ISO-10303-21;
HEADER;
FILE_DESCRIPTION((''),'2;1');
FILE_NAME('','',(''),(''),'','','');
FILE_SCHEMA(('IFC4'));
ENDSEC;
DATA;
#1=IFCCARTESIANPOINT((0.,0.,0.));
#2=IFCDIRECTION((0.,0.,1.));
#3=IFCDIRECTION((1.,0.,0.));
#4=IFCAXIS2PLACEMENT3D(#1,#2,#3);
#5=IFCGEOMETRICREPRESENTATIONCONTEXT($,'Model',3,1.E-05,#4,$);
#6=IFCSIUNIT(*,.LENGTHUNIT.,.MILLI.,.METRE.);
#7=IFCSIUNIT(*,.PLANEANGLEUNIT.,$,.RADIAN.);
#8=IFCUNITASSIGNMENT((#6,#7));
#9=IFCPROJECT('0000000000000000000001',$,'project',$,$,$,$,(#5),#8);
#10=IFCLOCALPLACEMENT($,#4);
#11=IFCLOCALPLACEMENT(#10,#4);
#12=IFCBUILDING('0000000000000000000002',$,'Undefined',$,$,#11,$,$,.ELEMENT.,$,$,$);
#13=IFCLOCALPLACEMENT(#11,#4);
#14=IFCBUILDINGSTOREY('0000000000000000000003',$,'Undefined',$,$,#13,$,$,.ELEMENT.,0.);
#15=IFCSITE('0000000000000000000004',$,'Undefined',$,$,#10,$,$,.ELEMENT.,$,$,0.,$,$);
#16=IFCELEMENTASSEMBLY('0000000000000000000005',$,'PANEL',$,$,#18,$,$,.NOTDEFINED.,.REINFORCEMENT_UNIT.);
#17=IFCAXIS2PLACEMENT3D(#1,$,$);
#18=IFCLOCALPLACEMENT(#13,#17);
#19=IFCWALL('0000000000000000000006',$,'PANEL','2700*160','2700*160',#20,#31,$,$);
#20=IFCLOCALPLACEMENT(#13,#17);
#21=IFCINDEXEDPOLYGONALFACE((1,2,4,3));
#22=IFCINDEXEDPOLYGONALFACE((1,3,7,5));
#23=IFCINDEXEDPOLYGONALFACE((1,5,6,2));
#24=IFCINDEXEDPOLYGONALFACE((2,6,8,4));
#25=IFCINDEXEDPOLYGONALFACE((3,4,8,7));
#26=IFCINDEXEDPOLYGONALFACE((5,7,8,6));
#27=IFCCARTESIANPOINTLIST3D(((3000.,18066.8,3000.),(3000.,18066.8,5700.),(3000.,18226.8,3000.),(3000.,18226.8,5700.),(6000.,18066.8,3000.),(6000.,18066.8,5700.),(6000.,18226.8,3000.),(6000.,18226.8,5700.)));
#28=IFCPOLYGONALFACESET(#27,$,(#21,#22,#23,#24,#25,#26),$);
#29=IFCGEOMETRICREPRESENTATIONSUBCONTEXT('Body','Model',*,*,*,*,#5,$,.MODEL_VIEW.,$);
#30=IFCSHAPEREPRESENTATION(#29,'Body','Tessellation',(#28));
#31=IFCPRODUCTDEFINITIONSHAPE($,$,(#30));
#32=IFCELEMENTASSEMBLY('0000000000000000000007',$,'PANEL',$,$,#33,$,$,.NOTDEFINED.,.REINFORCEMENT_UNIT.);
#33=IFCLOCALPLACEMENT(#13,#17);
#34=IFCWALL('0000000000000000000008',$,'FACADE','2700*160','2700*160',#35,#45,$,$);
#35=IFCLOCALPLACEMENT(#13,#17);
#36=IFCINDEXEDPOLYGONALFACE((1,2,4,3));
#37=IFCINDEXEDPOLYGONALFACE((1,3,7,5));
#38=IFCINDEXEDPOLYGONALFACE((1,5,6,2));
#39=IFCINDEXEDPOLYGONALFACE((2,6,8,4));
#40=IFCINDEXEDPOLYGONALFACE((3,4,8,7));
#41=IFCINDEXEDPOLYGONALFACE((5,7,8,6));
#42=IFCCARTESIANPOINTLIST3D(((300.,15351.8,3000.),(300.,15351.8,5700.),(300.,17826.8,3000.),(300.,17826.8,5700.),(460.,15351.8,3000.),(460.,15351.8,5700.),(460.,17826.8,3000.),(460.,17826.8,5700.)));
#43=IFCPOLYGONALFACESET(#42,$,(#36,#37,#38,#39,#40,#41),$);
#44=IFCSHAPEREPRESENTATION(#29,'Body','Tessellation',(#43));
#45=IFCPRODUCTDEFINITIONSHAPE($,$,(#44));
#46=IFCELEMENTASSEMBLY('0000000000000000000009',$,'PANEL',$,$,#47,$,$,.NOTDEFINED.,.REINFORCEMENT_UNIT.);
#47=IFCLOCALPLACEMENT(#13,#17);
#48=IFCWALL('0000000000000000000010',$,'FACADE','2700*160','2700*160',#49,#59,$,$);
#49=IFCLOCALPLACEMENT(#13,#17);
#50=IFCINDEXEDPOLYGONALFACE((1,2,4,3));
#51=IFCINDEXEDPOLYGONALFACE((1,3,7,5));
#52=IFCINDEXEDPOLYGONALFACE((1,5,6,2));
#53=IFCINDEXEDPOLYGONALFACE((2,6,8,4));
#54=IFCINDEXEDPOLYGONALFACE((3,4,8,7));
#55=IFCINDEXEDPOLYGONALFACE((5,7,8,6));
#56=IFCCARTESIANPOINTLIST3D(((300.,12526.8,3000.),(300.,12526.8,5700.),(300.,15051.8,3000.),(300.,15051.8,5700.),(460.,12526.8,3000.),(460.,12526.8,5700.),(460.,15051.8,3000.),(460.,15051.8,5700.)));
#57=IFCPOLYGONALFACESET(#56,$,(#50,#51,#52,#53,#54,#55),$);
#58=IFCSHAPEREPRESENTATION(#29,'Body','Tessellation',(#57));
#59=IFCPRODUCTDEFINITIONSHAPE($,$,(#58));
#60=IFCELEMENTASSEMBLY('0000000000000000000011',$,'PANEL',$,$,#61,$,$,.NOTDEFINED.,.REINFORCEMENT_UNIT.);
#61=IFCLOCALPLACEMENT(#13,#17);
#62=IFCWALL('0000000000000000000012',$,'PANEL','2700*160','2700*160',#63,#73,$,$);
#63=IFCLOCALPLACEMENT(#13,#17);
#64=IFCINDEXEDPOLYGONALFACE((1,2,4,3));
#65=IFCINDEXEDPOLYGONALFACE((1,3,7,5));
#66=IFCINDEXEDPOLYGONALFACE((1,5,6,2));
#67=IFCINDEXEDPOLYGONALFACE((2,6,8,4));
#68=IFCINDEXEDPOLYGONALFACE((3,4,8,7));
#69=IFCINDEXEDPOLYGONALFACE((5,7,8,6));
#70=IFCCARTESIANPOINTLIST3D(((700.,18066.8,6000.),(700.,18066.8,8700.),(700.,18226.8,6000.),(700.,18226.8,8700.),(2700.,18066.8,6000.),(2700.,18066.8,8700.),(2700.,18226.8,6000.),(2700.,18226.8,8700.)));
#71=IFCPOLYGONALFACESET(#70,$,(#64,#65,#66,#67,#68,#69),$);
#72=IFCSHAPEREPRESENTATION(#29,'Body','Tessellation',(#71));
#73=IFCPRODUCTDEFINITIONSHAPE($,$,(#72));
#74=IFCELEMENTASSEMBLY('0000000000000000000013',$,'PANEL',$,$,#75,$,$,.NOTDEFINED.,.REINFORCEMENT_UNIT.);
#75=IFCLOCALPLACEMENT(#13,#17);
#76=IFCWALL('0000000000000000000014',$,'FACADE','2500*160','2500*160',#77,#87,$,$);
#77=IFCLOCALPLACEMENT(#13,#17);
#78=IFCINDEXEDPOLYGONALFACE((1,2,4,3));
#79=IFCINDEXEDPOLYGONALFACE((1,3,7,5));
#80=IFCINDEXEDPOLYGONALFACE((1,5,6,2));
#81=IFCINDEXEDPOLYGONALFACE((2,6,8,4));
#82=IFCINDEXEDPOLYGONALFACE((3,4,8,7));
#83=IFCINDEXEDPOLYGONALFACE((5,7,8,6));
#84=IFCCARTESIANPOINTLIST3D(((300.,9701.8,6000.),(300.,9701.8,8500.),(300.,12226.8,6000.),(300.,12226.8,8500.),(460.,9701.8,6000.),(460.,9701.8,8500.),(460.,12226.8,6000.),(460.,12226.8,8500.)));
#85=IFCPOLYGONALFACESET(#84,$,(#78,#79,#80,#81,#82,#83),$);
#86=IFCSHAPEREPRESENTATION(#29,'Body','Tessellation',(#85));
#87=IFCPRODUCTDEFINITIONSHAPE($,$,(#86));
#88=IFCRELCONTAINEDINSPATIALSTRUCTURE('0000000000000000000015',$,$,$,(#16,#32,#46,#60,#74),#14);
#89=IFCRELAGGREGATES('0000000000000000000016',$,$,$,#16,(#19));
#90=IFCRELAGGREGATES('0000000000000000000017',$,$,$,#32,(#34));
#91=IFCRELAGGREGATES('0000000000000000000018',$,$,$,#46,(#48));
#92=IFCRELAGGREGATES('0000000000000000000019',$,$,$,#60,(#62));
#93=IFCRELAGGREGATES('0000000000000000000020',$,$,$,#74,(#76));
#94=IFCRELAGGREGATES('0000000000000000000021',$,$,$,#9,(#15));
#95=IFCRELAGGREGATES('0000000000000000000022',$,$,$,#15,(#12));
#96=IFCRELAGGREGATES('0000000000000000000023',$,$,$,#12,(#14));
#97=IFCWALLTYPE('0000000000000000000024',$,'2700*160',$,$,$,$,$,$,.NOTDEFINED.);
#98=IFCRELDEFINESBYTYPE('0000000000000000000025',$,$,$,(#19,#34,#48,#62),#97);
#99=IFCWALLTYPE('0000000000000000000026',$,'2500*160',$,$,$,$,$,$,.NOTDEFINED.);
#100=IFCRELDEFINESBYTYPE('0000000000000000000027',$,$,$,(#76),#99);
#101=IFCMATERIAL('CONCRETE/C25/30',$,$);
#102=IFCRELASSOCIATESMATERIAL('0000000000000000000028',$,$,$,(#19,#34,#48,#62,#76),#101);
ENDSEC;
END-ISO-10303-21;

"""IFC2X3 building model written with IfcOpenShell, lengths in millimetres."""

from ifc_helpers import new_model, si_unit, frame, frame_2d, origin_with_axes, place, context, subcontext, project, spatial, rectangle, extrude, material, type_object, element, aggregate, save


model = new_model("IFC2X3")

# Units and contexts
model_context = context("Model", 3, precision=1e-05, world=origin_with_axes())
body_context = subcontext(model_context, "Body", "Model", "MODEL_VIEW")
ifc_project = project(units=[si_unit("LENGTHUNIT", "METRE", prefix="MILLI"), si_unit("PLANEANGLEUNIT", "RADIAN")], contexts=[model_context])

# Site, building, storey
site_placement = place(None, origin_with_axes())
site = spatial("IfcSite", under=ifc_project, at=site_placement, Name="Undefined", CompositionType="ELEMENT", RefElevation=0.0)
building_placement = place(site_placement, origin_with_axes())
building = spatial("IfcBuilding", under=site, at=building_placement, Name="Undefined", CompositionType="ELEMENT")
storey_placement = place(building_placement, origin_with_axes())
storey = spatial("IfcBuildingStorey", under=building, at=storey_placement, Name="Undefined", CompositionType="ELEMENT", Elevation=0.0)

# Shared definitions
ifc_material = material(Name="CONCRETE/C25/30")

# Element assemblies, walls
wall_type_1 = type_object("IfcWallType", Name="2700*160", PredefinedType="NOTDEFINED")
assembly_1_placement = place(storey_placement, origin_with_axes())
assembly_1 = element("IfcElementAssembly", 1, at=assembly_1_placement, inside=storey, Name="PANEL", AssemblyPlace="NOTDEFINED", PredefinedType="REINFORCEMENT_UNIT")
wall_1_placement = place(assembly_1_placement, frame((3000.0, 18146.8, 3000.0), z_axis=(0.0, 0.0, 1.0), x_axis=(1.0, 0.0, 0.0)))
wall_1 = element("IfcWall", 2, at=wall_1_placement, type_object=wall_type_1, material=ifc_material, Name="PANEL", Description="2700*160", ObjectType="2700*160", context=body_context, shape_type="SweptSolid", body=[
    extrude(rectangle(XDim=3000.0, YDim=160.0, at=frame_2d((0.0, 1500.0), x_axis=(0.0, -1.0))), frame((0.0, 0.0, 0.0), z_axis=(0.0, 0.0, 1.0), x_axis=(0.0, -1.0, 0.0)), (0.0, 0.0, 1.0), 2700.0),
])
aggregate(assembly_1, [wall_1])
assembly_2_placement = place(storey_placement, origin_with_axes())
assembly_2 = element("IfcElementAssembly", 3, at=assembly_2_placement, inside=storey, Name="PANEL", AssemblyPlace="NOTDEFINED", PredefinedType="REINFORCEMENT_UNIT")
wall_2_placement = place(assembly_2_placement, frame((380.0, 17826.8, 3000.0), z_axis=(0.0, 0.0, 1.0), x_axis=(0.0, -1.0, 0.0)))
wall_2 = element("IfcWall", 4, at=wall_2_placement, type_object=wall_type_1, material=ifc_material, Name="FACADE", Description="2700*160", ObjectType="2700*160", context=body_context, shape_type="SweptSolid", body=[
    extrude(rectangle(XDim=2475.0, YDim=160.0, at=frame_2d((0.0, 1237.5), x_axis=(0.0, -1.0))), frame((0.0, 0.0, 0.0), z_axis=(0.0, 0.0, 1.0), x_axis=(0.0, -1.0, 0.0)), (0.0, 0.0, 1.0), 2700.0),
])
aggregate(assembly_2, [wall_2])
assembly_3_placement = place(storey_placement, origin_with_axes())
assembly_3 = element("IfcElementAssembly", 5, at=assembly_3_placement, inside=storey, Name="PANEL", AssemblyPlace="NOTDEFINED", PredefinedType="REINFORCEMENT_UNIT")
wall_3_placement = place(assembly_3_placement, frame((380.0, 15051.8, 3000.0), z_axis=(0.0, 0.0, 1.0), x_axis=(0.0, -1.0, 0.0)))
wall_3 = element("IfcWall", 6, at=wall_3_placement, type_object=wall_type_1, material=ifc_material, Name="FACADE", Description="2700*160", ObjectType="2700*160", context=body_context, shape_type="SweptSolid", body=[
    extrude(rectangle(XDim=2525.0, YDim=160.0, at=frame_2d((0.0, 1262.5), x_axis=(0.0, -1.0))), frame((0.0, 0.0, 0.0), z_axis=(0.0, 0.0, 1.0), x_axis=(0.0, -1.0, 0.0)), (0.0, 0.0, 1.0), 2700.0),
])
aggregate(assembly_3, [wall_3])
assembly_4_placement = place(storey_placement, origin_with_axes())
assembly_4 = element("IfcElementAssembly", 7, at=assembly_4_placement, inside=storey, Name="PANEL", AssemblyPlace="NOTDEFINED", PredefinedType="REINFORCEMENT_UNIT")
wall_4_placement = place(assembly_4_placement, frame((2700.0, 18146.8, 6000.0), z_axis=(0.0, 0.0, 1.0), x_axis=(-1.0, 0.0, 0.0)))
wall_4 = element("IfcWall", 8, at=wall_4_placement, type_object=wall_type_1, material=ifc_material, Name="PANEL", Description="2700*160", ObjectType="2700*160", context=body_context, shape_type="SweptSolid", body=[
    extrude(rectangle(XDim=2000.0, YDim=160.0, at=frame_2d((0.0, 1000.0), x_axis=(0.0, -1.0))), frame((0.0, 0.0, 0.0), z_axis=(0.0, 0.0, 1.0), x_axis=(0.0, -1.0, 0.0)), (0.0, 0.0, 1.0), 2700.0),
])
aggregate(assembly_4, [wall_4])
assembly_5_placement = place(storey_placement, origin_with_axes())
assembly_5 = element("IfcElementAssembly", 9, at=assembly_5_placement, inside=storey, Name="PANEL", AssemblyPlace="NOTDEFINED", PredefinedType="REINFORCEMENT_UNIT")
wall_type_2 = type_object("IfcWallType", Name="2500*160", PredefinedType="NOTDEFINED")
wall_5_placement = place(assembly_5_placement, frame((380.0, 12226.8, 6000.0), z_axis=(0.0, 0.0, 1.0), x_axis=(0.0, -1.0, 0.0)))
wall_5 = element("IfcWall", 10, at=wall_5_placement, type_object=wall_type_2, material=ifc_material, Name="FACADE", Description="2500*160", ObjectType="2500*160", context=body_context, shape_type="SweptSolid", body=[
    extrude(rectangle(XDim=2525.0, YDim=160.0, at=frame_2d((0.0, 1262.5), x_axis=(0.0, -1.0))), frame((0.0, 0.0, 0.0), z_axis=(0.0, 0.0, 1.0), x_axis=(0.0, -1.0, 0.0)), (0.0, 0.0, 1.0), 2500.0),
])
aggregate(assembly_5, [wall_5])

save(model, "model.ifc")
